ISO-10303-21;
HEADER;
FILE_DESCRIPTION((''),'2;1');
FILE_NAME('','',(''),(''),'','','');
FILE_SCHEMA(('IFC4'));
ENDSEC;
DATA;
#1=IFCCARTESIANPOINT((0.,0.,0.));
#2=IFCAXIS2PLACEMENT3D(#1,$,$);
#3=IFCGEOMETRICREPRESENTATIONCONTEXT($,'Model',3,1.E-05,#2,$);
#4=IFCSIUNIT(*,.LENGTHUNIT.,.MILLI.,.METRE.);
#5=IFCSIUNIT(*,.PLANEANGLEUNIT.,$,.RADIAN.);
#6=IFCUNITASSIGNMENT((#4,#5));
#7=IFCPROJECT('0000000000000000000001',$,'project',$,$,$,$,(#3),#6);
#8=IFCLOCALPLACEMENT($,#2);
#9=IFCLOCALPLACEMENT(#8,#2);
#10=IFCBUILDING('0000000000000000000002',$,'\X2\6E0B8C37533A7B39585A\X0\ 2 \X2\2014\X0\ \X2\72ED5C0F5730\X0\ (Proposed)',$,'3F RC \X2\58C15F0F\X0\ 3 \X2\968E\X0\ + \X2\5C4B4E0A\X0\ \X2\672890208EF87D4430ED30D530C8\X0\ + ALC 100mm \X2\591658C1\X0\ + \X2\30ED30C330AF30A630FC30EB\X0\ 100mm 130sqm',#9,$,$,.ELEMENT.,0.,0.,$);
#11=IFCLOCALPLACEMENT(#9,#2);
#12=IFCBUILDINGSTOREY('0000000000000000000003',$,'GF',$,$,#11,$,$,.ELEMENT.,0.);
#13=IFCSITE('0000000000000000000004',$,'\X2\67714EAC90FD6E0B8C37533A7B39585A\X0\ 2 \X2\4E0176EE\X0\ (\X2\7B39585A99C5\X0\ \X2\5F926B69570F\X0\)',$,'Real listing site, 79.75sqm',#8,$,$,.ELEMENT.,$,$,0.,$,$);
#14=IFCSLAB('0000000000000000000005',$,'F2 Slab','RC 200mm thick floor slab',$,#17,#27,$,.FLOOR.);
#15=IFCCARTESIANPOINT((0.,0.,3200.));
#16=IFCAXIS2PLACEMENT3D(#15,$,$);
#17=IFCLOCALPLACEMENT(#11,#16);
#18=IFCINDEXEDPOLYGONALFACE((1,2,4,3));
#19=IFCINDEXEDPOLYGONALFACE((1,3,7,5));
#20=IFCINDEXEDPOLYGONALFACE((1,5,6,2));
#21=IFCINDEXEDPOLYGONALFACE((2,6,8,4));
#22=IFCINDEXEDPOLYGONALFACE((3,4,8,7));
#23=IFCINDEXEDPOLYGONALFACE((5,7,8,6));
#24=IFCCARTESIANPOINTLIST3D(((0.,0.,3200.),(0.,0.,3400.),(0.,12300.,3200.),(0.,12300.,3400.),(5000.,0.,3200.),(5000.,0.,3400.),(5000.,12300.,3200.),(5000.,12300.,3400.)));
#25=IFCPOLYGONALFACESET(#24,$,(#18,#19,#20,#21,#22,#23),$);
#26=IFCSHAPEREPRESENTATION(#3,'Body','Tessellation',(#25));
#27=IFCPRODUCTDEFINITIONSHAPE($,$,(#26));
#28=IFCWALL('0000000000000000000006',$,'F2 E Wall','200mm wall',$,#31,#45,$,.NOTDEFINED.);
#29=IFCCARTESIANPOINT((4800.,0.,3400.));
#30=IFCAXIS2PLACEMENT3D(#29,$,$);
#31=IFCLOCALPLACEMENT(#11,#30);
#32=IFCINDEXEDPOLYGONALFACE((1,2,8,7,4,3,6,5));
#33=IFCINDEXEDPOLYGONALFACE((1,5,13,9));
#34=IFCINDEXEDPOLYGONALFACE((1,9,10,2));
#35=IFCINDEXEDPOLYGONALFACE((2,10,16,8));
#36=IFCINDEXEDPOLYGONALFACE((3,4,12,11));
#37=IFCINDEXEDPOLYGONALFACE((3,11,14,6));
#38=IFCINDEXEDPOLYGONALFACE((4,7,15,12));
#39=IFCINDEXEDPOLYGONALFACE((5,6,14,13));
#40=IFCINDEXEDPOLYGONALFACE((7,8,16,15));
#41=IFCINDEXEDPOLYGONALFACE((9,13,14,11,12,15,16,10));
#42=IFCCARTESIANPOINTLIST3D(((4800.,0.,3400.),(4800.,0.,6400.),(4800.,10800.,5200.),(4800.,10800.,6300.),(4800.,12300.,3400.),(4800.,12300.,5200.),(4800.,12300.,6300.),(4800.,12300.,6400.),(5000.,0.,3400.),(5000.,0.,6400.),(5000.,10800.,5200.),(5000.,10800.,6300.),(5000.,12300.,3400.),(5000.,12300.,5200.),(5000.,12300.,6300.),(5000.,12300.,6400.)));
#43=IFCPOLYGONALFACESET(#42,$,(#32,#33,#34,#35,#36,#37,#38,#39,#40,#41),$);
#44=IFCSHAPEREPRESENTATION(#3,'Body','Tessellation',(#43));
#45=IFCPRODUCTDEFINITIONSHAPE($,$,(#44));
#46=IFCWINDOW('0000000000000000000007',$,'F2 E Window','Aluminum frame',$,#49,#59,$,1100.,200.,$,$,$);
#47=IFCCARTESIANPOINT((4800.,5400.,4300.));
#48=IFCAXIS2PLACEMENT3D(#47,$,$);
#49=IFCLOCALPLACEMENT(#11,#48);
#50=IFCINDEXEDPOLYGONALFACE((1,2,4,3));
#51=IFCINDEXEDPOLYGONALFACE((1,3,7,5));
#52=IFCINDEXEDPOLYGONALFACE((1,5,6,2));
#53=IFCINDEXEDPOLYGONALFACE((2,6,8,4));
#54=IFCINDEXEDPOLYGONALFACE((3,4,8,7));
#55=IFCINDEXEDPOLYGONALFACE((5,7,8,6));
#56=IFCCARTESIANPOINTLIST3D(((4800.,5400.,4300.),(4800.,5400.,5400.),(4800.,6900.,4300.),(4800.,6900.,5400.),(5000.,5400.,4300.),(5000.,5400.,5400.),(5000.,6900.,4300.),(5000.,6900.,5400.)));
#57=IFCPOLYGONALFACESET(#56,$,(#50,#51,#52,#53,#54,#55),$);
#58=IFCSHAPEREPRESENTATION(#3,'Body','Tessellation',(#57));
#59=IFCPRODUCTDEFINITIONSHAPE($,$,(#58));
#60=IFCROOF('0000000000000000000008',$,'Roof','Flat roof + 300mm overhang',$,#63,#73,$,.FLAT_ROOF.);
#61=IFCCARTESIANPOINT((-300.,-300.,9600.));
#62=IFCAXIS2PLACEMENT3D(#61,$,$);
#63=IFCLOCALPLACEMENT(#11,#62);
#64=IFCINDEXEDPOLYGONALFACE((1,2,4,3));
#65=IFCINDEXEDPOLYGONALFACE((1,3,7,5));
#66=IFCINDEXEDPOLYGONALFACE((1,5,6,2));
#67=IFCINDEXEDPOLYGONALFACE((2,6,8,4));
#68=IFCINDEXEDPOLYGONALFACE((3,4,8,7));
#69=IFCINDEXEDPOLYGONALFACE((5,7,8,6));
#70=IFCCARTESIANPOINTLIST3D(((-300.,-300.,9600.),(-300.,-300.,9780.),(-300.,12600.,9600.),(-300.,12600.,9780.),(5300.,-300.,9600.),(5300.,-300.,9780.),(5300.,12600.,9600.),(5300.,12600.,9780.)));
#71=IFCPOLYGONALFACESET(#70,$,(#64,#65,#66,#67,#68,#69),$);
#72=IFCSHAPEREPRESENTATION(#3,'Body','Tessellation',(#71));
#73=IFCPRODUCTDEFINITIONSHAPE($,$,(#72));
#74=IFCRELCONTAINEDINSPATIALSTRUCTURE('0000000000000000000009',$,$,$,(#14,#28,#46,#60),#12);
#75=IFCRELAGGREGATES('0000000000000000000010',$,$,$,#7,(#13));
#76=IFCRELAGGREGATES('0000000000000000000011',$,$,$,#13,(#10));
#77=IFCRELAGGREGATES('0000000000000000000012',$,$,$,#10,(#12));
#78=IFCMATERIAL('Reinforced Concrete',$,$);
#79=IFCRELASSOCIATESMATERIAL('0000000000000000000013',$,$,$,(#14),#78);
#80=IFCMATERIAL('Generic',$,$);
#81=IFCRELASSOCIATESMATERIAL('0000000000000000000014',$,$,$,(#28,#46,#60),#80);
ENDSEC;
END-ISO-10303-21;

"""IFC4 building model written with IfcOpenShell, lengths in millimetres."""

from ifc_helpers import new_model, si_unit, frame, frame_2d, origin, place, context, project, spatial, rectangle, extrude, material, element, fill, save


model = new_model("IFC4")

# Units and contexts
model_context = context("Model", 3, precision=1e-05, world=origin())
ifc_project = project(units=[si_unit("LENGTHUNIT", "METRE", prefix="MILLI"), si_unit("PLANEANGLEUNIT", "RADIAN")], contexts=[model_context])

# Site, building, storey
site_placement = place(None, origin())
site = spatial("IfcSite", under=ifc_project, at=site_placement, Name="東京都渋谷区笹塚 2 丁目 (笹塚駅 徒歩圏)", ObjectType="Real listing site, 79.75sqm", CompositionType="ELEMENT", RefElevation=0.0)
building_placement = place(site_placement, origin())
building = spatial("IfcBuilding", under=site, at=building_placement, Name="渋谷区笹塚 2 — 狭小地 (Proposed)", ObjectType="3F RC 壁式 3 階 + 屋上 木造軸組ロフト + ALC 100mm 外壁 + ロックウール 100mm 130sqm", CompositionType="ELEMENT", ElevationOfRefHeight=0.0, ElevationOfTerrain=0.0)
storey_placement = place(building_placement, origin())
storey = spatial("IfcBuildingStorey", under=building, at=storey_placement, Name="GF", CompositionType="ELEMENT", Elevation=0.0)

# Slab
ifc_material_1 = material(Name="Reinforced Concrete")
slab_1_placement = place(storey_placement, frame((0.0, 0.0, 3200.0)))
element("IfcSlab", 1, at=slab_1_placement, inside=storey, material=ifc_material_1, Name="F2 Slab", Description="RC 200mm thick floor slab", PredefinedType="FLOOR", context=model_context, shape_type="SweptSolid", body=[
    extrude(rectangle(XDim=5000.0, YDim=12300.0, at=frame_2d((2500.0, 6150.0))), frame((0.0, 0.0, 3200.0)), (0.0, 0.0, 1.0), 200.0),
])

# Shared definitions
ifc_material_2 = material(Name="Generic")

# Wall, opening, window
wall_1_placement = place(storey_placement, frame((4800.0, 0.0, 3400.0)))
wall_1 = element("IfcWall", 2, at=wall_1_placement, inside=storey, material=ifc_material_2, Name="F2 E Wall", Description="200mm wall", PredefinedType="NOTDEFINED", context=model_context, shape_type="SweptSolid", body=[
    extrude(rectangle(XDim=200.0, YDim=12300.0, at=frame_2d((100.0, 6150.0))), frame((4800.0, 0.0, 3400.0)), (0.0, 0.0, 1.0), 3000.0),
])
opening_1_placement = place(storey_placement, frame((4800.0, 5400.0, 4300.0)))
opening_1 = element("IfcOpeningElement", 3, at=opening_1_placement, cuts=wall_1, PredefinedType="NOTDEFINED", context=model_context, shape_type="SweptSolid", body=[
    extrude(rectangle(XDim=200.0, YDim=1500.0, at=frame_2d((100.0, 750.0))), frame((4800.0, 5400.0, 4300.0)), (0.0, 0.0, 1.0), 1100.0),
])
window_1_placement = place(storey_placement, frame((4800.0, 5400.0, 4300.0)))
window_1 = element("IfcWindow", 4, at=window_1_placement, inside=storey, material=ifc_material_2, Name="F2 E Window", Description="Aluminum frame", OverallHeight=1100.0, OverallWidth=200.0, context=model_context, shape_type="SweptSolid", body=[
    extrude(rectangle(XDim=200.0, YDim=1500.0, at=frame_2d((100.0, 750.0))), frame((4800.0, 5400.0, 4300.0)), (0.0, 0.0, 1.0), 1100.0),
])
fill(opening_1, window_1)

# Roof
roof_placement = place(storey_placement, frame((-300.0, -300.0, 9600.0)))
element("IfcRoof", 5, at=roof_placement, inside=storey, material=ifc_material_2, Name="Roof", Description="Flat roof + 300mm overhang", PredefinedType="FLAT_ROOF", context=model_context, shape_type="SweptSolid", body=[
    extrude(rectangle(XDim=5600.0, YDim=12900.0, at=frame_2d((2800.0, 6450.0))), frame((-300.0, -300.0, 9600.0)), (0.0, 0.0, 1.0), 180.0),
])

save(model, "model.ifc")
